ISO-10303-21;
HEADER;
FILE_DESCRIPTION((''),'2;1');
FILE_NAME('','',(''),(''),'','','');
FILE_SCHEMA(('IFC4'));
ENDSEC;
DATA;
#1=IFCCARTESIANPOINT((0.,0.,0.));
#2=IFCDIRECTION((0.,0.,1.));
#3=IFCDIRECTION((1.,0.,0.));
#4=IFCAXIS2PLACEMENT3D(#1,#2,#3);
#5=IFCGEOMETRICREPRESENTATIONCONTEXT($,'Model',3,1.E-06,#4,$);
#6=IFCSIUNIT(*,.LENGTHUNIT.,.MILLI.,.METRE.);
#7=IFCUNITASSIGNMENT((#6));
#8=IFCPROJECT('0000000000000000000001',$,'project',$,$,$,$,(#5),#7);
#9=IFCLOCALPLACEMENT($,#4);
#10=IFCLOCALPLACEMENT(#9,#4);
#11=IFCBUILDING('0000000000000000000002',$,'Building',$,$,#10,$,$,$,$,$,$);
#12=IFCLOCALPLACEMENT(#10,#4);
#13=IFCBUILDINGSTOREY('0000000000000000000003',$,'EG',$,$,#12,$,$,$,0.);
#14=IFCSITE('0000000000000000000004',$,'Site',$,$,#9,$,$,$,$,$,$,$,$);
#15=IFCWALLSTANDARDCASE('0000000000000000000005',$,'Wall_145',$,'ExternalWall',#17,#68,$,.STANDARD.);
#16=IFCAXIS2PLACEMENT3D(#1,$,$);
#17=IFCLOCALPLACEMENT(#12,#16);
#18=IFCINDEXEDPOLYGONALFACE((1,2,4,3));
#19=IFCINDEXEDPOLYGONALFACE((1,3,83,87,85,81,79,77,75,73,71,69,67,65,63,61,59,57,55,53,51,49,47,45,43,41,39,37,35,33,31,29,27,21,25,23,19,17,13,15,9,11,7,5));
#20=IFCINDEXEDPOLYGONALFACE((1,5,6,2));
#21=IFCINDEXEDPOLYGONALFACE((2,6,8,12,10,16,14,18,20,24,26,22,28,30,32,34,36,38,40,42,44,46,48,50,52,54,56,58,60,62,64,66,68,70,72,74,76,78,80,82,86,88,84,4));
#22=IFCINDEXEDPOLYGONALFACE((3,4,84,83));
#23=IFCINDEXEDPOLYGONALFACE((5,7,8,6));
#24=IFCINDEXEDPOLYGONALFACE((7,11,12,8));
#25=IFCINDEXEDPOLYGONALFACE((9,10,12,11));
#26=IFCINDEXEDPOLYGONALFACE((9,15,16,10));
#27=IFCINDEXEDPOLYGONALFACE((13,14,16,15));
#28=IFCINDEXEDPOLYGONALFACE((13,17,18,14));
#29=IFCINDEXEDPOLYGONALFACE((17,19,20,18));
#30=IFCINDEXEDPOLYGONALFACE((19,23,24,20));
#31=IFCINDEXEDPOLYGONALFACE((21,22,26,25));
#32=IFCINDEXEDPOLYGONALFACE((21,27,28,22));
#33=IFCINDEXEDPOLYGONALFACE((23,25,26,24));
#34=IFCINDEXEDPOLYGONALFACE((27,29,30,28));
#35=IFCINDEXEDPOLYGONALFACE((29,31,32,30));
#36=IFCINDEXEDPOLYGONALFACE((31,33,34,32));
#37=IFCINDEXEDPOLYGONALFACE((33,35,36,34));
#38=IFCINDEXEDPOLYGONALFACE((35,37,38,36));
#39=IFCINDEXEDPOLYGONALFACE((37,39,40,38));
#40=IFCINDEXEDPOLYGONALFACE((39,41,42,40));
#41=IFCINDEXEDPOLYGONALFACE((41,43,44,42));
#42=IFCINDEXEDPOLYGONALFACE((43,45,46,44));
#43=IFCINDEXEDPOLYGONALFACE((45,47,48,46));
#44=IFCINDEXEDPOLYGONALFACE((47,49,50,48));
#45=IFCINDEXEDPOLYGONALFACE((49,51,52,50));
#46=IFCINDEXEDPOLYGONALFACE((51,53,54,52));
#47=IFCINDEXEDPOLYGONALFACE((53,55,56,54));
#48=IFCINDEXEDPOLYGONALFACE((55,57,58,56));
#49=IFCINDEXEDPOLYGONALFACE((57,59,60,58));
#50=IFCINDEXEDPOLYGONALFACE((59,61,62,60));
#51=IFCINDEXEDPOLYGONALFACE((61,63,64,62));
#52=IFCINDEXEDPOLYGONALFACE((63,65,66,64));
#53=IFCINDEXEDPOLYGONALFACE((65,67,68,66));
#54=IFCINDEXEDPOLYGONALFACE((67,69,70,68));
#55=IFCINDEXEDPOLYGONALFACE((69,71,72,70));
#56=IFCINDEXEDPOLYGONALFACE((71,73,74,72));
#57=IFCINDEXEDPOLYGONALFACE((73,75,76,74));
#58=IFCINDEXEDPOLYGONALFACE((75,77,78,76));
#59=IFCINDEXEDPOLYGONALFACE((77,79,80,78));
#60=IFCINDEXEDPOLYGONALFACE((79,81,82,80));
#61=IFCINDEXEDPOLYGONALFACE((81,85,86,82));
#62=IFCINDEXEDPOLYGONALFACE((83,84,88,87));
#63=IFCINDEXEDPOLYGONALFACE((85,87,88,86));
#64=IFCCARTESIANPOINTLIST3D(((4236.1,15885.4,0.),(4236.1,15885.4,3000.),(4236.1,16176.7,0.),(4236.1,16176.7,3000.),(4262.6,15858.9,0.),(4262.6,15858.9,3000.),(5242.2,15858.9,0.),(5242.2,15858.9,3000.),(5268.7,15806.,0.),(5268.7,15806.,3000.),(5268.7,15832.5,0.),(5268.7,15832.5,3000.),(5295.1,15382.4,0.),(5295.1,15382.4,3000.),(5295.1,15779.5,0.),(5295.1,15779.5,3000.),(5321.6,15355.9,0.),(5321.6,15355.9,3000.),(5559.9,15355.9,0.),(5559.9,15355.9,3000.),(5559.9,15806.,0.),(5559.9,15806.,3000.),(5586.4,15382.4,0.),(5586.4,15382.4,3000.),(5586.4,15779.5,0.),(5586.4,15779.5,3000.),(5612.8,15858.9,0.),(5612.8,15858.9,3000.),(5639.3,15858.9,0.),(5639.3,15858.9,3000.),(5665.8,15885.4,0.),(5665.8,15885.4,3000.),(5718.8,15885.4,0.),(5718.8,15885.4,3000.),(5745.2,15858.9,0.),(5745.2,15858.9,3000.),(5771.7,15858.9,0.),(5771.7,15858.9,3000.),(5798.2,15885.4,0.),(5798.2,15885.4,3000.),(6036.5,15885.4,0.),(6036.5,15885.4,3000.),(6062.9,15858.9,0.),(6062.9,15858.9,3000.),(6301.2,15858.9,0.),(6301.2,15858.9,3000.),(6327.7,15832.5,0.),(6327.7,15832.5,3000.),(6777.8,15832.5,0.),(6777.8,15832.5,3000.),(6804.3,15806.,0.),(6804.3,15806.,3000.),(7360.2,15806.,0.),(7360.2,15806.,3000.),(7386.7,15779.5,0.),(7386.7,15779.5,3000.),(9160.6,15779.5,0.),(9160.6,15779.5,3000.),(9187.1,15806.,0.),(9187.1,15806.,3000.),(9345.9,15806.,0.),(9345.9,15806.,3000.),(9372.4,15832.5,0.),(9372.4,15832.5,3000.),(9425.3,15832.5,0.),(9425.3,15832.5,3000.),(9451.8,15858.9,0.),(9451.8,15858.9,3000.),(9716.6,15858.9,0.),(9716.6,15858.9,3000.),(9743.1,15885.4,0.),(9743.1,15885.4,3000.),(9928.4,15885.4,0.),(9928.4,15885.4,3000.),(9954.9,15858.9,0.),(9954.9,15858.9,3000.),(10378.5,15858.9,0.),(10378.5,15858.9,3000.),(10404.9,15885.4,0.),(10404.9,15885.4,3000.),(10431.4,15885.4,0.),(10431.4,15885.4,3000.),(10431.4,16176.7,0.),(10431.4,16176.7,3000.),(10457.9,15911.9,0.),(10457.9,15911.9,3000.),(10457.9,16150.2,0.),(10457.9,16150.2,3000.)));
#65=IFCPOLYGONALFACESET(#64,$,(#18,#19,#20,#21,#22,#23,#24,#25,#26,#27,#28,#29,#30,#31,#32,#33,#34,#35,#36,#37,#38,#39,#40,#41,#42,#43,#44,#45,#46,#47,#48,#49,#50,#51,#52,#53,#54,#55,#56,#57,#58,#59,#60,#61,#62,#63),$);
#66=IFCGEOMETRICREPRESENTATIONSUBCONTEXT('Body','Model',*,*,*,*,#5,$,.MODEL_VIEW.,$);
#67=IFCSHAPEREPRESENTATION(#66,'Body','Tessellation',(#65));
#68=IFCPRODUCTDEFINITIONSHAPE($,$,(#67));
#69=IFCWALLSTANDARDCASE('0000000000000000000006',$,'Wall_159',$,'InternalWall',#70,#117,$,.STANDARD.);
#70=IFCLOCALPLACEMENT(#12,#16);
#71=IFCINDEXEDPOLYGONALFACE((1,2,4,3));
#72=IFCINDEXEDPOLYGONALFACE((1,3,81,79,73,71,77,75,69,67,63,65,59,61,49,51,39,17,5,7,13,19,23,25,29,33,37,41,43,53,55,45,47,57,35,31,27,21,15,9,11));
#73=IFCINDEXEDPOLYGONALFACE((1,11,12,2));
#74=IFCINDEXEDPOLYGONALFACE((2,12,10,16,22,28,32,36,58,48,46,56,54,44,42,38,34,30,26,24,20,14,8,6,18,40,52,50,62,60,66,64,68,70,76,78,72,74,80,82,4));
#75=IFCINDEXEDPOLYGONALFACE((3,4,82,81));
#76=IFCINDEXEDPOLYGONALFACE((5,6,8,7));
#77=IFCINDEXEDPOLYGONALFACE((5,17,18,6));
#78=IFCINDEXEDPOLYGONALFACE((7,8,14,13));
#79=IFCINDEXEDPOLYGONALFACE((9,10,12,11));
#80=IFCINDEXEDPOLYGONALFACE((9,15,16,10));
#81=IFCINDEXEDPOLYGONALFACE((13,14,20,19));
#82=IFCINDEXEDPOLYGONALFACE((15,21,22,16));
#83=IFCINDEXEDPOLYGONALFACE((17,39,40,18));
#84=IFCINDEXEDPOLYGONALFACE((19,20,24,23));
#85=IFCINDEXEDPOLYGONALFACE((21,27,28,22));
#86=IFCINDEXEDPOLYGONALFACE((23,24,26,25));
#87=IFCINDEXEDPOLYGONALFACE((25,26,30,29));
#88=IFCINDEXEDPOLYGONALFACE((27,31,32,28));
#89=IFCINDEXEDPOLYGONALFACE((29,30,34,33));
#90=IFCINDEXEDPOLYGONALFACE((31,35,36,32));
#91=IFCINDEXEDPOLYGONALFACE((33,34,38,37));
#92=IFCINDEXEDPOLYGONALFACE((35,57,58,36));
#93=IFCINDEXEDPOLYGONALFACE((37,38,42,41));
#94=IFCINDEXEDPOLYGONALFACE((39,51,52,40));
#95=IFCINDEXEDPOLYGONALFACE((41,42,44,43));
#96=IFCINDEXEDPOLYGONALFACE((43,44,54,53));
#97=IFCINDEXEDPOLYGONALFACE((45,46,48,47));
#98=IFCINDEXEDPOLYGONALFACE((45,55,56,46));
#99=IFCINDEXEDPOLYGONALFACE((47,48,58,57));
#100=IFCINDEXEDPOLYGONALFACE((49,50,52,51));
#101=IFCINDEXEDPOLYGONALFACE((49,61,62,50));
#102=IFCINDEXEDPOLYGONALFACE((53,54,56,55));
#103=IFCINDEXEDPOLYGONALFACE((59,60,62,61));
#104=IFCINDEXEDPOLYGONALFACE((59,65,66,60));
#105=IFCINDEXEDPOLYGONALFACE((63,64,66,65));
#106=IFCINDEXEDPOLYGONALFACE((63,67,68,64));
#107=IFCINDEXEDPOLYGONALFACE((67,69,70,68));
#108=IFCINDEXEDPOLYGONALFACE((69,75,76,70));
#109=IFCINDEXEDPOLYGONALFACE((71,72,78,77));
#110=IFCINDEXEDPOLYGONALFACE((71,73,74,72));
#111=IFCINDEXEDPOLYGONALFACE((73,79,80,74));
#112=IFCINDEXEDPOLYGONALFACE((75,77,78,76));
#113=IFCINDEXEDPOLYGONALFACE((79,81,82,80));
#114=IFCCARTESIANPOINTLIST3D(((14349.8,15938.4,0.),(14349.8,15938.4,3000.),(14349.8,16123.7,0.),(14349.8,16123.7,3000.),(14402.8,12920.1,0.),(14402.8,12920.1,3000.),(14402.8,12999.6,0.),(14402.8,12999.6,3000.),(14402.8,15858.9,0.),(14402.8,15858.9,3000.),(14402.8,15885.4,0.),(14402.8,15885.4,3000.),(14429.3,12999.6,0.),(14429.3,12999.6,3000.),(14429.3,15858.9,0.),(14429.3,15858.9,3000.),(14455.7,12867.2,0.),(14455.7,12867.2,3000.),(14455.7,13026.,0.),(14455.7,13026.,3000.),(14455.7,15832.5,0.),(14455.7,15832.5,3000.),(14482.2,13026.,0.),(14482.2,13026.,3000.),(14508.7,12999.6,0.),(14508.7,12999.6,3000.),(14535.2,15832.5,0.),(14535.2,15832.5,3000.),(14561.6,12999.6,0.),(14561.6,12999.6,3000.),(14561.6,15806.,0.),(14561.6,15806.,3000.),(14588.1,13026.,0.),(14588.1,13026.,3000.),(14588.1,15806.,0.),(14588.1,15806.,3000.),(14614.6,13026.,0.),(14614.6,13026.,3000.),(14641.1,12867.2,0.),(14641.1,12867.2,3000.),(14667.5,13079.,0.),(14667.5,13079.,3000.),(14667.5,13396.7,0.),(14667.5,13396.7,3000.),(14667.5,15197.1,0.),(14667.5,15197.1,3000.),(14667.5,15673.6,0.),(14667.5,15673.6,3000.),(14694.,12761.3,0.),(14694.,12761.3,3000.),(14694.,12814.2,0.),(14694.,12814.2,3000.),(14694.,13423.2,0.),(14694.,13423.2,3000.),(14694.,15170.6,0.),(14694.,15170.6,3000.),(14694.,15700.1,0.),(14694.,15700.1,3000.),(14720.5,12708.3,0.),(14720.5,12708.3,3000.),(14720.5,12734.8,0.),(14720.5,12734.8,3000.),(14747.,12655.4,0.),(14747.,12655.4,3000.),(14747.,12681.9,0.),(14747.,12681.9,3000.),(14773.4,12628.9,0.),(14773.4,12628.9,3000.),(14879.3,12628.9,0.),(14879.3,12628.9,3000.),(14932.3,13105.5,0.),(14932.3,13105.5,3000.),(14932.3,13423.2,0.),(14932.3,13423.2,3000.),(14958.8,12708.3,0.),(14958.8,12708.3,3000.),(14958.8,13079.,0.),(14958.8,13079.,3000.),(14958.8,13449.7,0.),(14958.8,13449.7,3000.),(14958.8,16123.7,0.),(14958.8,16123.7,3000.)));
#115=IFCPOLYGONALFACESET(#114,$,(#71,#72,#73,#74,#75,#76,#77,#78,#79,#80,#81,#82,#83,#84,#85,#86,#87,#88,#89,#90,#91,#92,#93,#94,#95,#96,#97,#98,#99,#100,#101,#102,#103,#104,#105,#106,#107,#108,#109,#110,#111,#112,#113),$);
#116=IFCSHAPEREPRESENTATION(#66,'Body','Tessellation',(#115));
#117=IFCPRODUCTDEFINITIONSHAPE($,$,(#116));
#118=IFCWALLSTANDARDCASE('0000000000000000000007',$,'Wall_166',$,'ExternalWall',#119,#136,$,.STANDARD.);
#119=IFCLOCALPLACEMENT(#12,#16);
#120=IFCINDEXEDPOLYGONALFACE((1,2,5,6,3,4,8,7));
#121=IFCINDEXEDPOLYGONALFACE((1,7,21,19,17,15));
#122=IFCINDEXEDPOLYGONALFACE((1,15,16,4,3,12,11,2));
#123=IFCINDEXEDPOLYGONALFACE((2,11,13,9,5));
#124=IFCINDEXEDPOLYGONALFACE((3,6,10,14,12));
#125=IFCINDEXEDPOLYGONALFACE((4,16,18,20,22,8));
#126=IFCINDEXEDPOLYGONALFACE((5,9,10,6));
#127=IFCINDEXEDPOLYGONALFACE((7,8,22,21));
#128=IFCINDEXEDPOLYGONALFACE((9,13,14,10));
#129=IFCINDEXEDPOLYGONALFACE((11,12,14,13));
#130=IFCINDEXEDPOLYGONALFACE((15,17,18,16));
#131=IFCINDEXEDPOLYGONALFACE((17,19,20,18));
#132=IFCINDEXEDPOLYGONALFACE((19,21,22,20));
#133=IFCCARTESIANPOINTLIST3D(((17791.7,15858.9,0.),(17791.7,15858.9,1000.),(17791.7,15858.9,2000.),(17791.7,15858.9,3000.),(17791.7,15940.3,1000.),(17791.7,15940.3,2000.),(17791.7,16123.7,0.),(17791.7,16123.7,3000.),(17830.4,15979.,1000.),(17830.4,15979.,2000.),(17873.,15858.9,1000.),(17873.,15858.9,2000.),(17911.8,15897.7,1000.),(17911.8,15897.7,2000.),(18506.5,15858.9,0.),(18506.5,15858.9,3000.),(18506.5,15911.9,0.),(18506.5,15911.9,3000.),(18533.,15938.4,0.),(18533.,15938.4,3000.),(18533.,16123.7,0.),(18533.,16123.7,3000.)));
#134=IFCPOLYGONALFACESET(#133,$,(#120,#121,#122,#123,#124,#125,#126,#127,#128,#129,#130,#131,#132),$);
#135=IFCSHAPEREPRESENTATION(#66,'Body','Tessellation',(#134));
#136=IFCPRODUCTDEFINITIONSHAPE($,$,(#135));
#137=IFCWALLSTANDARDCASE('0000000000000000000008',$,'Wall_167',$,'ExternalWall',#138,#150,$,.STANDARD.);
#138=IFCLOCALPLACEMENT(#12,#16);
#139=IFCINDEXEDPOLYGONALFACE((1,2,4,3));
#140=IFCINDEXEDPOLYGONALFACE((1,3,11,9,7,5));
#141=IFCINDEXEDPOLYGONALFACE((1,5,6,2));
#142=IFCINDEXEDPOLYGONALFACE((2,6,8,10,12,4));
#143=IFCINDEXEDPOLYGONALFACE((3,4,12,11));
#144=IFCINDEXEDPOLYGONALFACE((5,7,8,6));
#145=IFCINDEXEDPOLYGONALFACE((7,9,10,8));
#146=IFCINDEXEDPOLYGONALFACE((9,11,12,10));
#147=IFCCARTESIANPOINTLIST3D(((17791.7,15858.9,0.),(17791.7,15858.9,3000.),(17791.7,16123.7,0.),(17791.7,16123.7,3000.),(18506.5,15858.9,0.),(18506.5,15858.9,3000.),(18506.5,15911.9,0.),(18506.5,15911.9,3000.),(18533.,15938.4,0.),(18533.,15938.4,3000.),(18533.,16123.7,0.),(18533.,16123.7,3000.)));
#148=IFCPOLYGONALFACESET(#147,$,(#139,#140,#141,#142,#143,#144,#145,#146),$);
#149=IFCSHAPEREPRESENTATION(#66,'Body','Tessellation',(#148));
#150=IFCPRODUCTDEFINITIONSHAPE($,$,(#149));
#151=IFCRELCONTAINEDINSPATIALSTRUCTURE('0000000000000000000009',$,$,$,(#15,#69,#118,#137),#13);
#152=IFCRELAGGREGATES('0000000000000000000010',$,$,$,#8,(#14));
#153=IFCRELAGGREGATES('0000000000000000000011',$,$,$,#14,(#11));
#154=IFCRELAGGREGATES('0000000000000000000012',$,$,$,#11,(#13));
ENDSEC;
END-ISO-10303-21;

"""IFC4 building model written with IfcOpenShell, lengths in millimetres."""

from ifc_helpers import new_model, si_unit, frame, origin_with_axes, place, context, subcontext, project, spatial, polyline, rectangle, outline, extrude, element, save


model = new_model("IFC4")

# Units and contexts
model_context = context("Model", 3, precision=1e-06, world=origin_with_axes())
body_context = subcontext(model_context, "Body", "Model", "MODEL_VIEW")
ifc_project = project(units=[si_unit("LENGTHUNIT", "METRE", prefix="MILLI")], contexts=[model_context])

# Site, building, storey
site_placement = place(None, origin_with_axes())
site = spatial("IfcSite", under=ifc_project, at=site_placement, Name="Site")
building_placement = place(site_placement, origin_with_axes())
building = spatial("IfcBuilding", under=site, at=building_placement, Name="Building")
storey_placement = place(building_placement, origin_with_axes())
storey = spatial("IfcBuildingStorey", under=building, at=storey_placement, Name="EG", Elevation=0.0)

# Walls
wall_1_placement = place(storey_placement, origin_with_axes())
element("IfcWallStandardCase", 1, at=wall_1_placement, inside=storey, Name="Wall_145", ObjectType="ExternalWall", PredefinedType="STANDARD", context=body_context, shape_type="SweptSolid", body=[
    extrude(outline(polyline([(5321.6, 15355.9, 0.0), (5295.1, 15382.4, 0.0), (5295.1, 15779.5, 0.0), (5268.7, 15806.0, 0.0), (5268.7, 15832.5, 0.0), (5242.2, 15858.9, 0.0), (4262.6, 15858.9, 0.0), (4236.1, 15885.4, 0.0), (4236.1, 16176.7, 0.0), (10431.4, 16176.7, 0.0), (10457.9, 16150.2, 0.0), (10457.9, 15911.9, 0.0), (10431.4, 15885.4, 0.0), (10404.9, 15885.4, 0.0), (10378.5, 15858.9, 0.0), (9954.9, 15858.9, 0.0), (9928.4, 15885.4, 0.0), (9743.1, 15885.4, 0.0), (9716.6, 15858.9, 0.0), (9451.8, 15858.9, 0.0), (9425.3, 15832.5, 0.0), (9372.4, 15832.5, 0.0), (9345.9, 15806.0, 0.0), (9187.1, 15806.0, 0.0), (9160.6, 15779.5, 0.0), (7386.7, 15779.5, 0.0), (7360.2, 15806.0, 0.0), (6804.3, 15806.0, 0.0), (6777.8, 15832.5, 0.0), (6327.7, 15832.5, 0.0), (6301.2, 15858.9, 0.0), (6062.9, 15858.9, 0.0), (6036.5, 15885.4, 0.0), (5798.2, 15885.4, 0.0), (5771.7, 15858.9, 0.0), (5745.2, 15858.9, 0.0), (5718.8, 15885.4, 0.0), (5665.8, 15885.4, 0.0), (5639.3, 15858.9, 0.0), (5612.8, 15858.9, 0.0), (5559.9, 15806.0, 0.0), (5586.4, 15779.5, 0.0), (5586.4, 15382.4, 0.0), (5559.9, 15355.9, 0.0), (5321.6, 15355.9, 0.0)])), origin_with_axes(), (0.0, 0.0, 1.0), 3000.0),
])
wall_2_placement = place(storey_placement, origin_with_axes())
element("IfcWallStandardCase", 2, at=wall_2_placement, inside=storey, Name="Wall_159", ObjectType="InternalWall", PredefinedType="STANDARD", context=body_context, shape_type="SweptSolid", body=[
    extrude(outline(polyline([(14773.4, 12628.9, 0.0), (14747.0, 12655.4, 0.0), (14747.0, 12681.9, 0.0), (14720.5, 12708.3, 0.0), (14720.5, 12734.8, 0.0), (14694.0, 12761.3, 0.0), (14694.0, 12814.2, 0.0), (14641.1, 12867.2, 0.0), (14455.7, 12867.2, 0.0), (14402.8, 12920.1, 0.0), (14402.8, 12999.6, 0.0), (14429.3, 12999.6, 0.0), (14455.7, 13026.0, 0.0), (14482.2, 13026.0, 0.0), (14508.7, 12999.6, 0.0), (14561.6, 12999.6, 0.0), (14588.1, 13026.0, 0.0), (14614.6, 13026.0, 0.0), (14667.5, 13079.0, 0.0), (14667.5, 13396.7, 0.0), (14694.0, 13423.2, 0.0), (14694.0, 15170.6, 0.0), (14667.5, 15197.1, 0.0), (14667.5, 15673.6, 0.0), (14694.0, 15700.1, 0.0), (14588.1, 15806.0, 0.0), (14561.6, 15806.0, 0.0), (14535.2, 15832.5, 0.0), (14455.7, 15832.5, 0.0), (14429.3, 15858.9, 0.0), (14402.8, 15858.9, 0.0), (14402.8, 15885.4, 0.0), (14349.8, 15938.4, 0.0), (14349.8, 16123.7, 0.0), (14958.8, 16123.7, 0.0), (14958.8, 13449.7, 0.0), (14932.3, 13423.2, 0.0), (14932.3, 13105.5, 0.0), (14958.8, 13079.0, 0.0), (14958.8, 12708.3, 0.0), (14879.3, 12628.9, 0.0), (14773.4, 12628.9, 0.0)])), origin_with_axes(), (0.0, 0.0, 1.0), 3000.0),
])

# Wall, opening
wall_3_placement = place(storey_placement, origin_with_axes())
wall_3 = element("IfcWallStandardCase", 3, at=wall_3_placement, inside=storey, Name="Wall_166", ObjectType="ExternalWall", PredefinedType="STANDARD", context=body_context, shape_type="SweptSolid", body=[
    extrude(outline(polyline([(17791.7, 15858.9, 0.0), (17791.7, 16123.7, 0.0), (18533.0, 16123.7, 0.0), (18533.0, 15938.4, 0.0), (18506.5, 15911.9, 0.0), (18506.5, 15858.9, 0.0), (17791.7, 15858.9, 0.0)])), origin_with_axes(), (0.0, 0.0, 1.0), 3000.0),
])
opening_placement = place(wall_3_placement, origin_with_axes())
element("IfcOpeningElement", 4, at=opening_placement, inside=storey, cuts=wall_3, context=body_context, shape_type="SweptSolid", body=[
    extrude(rectangle(XDim=823.7, YDim=115.0), frame((17579.9, 15647.1, 1000.0), z_axis=(0.0, 0.0, 1.0), x_axis=(-0.707107, -0.707107, 0.0)), (0.0, 0.0, 1.0), 1000.0),
])

# Wall
for number, where, z_axis, x_axis, name in (
    (5, (0.0, 0.0, 0.0), (0.0, 0.0, 1.0), (1.0, 0.0, 0.0), "Wall_167"),
):
    element("IfcWallStandardCase", number, at=place(storey_placement, frame(where, z_axis=z_axis, x_axis=x_axis)), inside=storey, Name=name, ObjectType="ExternalWall", PredefinedType="STANDARD", context=body_context, shape_type="SweptSolid", body=[
        extrude(outline(polyline([(17791.7, 15858.9, 0.0), (17791.7, 16123.7, 0.0), (18533.0, 16123.7, 0.0), (18533.0, 15938.4, 0.0), (18506.5, 15911.9, 0.0), (18506.5, 15858.9, 0.0), (17791.7, 15858.9, 0.0)])), origin_with_axes(), (0.0, 0.0, 1.0), 3000.0),
    ])

save(model, "model.ifc")
